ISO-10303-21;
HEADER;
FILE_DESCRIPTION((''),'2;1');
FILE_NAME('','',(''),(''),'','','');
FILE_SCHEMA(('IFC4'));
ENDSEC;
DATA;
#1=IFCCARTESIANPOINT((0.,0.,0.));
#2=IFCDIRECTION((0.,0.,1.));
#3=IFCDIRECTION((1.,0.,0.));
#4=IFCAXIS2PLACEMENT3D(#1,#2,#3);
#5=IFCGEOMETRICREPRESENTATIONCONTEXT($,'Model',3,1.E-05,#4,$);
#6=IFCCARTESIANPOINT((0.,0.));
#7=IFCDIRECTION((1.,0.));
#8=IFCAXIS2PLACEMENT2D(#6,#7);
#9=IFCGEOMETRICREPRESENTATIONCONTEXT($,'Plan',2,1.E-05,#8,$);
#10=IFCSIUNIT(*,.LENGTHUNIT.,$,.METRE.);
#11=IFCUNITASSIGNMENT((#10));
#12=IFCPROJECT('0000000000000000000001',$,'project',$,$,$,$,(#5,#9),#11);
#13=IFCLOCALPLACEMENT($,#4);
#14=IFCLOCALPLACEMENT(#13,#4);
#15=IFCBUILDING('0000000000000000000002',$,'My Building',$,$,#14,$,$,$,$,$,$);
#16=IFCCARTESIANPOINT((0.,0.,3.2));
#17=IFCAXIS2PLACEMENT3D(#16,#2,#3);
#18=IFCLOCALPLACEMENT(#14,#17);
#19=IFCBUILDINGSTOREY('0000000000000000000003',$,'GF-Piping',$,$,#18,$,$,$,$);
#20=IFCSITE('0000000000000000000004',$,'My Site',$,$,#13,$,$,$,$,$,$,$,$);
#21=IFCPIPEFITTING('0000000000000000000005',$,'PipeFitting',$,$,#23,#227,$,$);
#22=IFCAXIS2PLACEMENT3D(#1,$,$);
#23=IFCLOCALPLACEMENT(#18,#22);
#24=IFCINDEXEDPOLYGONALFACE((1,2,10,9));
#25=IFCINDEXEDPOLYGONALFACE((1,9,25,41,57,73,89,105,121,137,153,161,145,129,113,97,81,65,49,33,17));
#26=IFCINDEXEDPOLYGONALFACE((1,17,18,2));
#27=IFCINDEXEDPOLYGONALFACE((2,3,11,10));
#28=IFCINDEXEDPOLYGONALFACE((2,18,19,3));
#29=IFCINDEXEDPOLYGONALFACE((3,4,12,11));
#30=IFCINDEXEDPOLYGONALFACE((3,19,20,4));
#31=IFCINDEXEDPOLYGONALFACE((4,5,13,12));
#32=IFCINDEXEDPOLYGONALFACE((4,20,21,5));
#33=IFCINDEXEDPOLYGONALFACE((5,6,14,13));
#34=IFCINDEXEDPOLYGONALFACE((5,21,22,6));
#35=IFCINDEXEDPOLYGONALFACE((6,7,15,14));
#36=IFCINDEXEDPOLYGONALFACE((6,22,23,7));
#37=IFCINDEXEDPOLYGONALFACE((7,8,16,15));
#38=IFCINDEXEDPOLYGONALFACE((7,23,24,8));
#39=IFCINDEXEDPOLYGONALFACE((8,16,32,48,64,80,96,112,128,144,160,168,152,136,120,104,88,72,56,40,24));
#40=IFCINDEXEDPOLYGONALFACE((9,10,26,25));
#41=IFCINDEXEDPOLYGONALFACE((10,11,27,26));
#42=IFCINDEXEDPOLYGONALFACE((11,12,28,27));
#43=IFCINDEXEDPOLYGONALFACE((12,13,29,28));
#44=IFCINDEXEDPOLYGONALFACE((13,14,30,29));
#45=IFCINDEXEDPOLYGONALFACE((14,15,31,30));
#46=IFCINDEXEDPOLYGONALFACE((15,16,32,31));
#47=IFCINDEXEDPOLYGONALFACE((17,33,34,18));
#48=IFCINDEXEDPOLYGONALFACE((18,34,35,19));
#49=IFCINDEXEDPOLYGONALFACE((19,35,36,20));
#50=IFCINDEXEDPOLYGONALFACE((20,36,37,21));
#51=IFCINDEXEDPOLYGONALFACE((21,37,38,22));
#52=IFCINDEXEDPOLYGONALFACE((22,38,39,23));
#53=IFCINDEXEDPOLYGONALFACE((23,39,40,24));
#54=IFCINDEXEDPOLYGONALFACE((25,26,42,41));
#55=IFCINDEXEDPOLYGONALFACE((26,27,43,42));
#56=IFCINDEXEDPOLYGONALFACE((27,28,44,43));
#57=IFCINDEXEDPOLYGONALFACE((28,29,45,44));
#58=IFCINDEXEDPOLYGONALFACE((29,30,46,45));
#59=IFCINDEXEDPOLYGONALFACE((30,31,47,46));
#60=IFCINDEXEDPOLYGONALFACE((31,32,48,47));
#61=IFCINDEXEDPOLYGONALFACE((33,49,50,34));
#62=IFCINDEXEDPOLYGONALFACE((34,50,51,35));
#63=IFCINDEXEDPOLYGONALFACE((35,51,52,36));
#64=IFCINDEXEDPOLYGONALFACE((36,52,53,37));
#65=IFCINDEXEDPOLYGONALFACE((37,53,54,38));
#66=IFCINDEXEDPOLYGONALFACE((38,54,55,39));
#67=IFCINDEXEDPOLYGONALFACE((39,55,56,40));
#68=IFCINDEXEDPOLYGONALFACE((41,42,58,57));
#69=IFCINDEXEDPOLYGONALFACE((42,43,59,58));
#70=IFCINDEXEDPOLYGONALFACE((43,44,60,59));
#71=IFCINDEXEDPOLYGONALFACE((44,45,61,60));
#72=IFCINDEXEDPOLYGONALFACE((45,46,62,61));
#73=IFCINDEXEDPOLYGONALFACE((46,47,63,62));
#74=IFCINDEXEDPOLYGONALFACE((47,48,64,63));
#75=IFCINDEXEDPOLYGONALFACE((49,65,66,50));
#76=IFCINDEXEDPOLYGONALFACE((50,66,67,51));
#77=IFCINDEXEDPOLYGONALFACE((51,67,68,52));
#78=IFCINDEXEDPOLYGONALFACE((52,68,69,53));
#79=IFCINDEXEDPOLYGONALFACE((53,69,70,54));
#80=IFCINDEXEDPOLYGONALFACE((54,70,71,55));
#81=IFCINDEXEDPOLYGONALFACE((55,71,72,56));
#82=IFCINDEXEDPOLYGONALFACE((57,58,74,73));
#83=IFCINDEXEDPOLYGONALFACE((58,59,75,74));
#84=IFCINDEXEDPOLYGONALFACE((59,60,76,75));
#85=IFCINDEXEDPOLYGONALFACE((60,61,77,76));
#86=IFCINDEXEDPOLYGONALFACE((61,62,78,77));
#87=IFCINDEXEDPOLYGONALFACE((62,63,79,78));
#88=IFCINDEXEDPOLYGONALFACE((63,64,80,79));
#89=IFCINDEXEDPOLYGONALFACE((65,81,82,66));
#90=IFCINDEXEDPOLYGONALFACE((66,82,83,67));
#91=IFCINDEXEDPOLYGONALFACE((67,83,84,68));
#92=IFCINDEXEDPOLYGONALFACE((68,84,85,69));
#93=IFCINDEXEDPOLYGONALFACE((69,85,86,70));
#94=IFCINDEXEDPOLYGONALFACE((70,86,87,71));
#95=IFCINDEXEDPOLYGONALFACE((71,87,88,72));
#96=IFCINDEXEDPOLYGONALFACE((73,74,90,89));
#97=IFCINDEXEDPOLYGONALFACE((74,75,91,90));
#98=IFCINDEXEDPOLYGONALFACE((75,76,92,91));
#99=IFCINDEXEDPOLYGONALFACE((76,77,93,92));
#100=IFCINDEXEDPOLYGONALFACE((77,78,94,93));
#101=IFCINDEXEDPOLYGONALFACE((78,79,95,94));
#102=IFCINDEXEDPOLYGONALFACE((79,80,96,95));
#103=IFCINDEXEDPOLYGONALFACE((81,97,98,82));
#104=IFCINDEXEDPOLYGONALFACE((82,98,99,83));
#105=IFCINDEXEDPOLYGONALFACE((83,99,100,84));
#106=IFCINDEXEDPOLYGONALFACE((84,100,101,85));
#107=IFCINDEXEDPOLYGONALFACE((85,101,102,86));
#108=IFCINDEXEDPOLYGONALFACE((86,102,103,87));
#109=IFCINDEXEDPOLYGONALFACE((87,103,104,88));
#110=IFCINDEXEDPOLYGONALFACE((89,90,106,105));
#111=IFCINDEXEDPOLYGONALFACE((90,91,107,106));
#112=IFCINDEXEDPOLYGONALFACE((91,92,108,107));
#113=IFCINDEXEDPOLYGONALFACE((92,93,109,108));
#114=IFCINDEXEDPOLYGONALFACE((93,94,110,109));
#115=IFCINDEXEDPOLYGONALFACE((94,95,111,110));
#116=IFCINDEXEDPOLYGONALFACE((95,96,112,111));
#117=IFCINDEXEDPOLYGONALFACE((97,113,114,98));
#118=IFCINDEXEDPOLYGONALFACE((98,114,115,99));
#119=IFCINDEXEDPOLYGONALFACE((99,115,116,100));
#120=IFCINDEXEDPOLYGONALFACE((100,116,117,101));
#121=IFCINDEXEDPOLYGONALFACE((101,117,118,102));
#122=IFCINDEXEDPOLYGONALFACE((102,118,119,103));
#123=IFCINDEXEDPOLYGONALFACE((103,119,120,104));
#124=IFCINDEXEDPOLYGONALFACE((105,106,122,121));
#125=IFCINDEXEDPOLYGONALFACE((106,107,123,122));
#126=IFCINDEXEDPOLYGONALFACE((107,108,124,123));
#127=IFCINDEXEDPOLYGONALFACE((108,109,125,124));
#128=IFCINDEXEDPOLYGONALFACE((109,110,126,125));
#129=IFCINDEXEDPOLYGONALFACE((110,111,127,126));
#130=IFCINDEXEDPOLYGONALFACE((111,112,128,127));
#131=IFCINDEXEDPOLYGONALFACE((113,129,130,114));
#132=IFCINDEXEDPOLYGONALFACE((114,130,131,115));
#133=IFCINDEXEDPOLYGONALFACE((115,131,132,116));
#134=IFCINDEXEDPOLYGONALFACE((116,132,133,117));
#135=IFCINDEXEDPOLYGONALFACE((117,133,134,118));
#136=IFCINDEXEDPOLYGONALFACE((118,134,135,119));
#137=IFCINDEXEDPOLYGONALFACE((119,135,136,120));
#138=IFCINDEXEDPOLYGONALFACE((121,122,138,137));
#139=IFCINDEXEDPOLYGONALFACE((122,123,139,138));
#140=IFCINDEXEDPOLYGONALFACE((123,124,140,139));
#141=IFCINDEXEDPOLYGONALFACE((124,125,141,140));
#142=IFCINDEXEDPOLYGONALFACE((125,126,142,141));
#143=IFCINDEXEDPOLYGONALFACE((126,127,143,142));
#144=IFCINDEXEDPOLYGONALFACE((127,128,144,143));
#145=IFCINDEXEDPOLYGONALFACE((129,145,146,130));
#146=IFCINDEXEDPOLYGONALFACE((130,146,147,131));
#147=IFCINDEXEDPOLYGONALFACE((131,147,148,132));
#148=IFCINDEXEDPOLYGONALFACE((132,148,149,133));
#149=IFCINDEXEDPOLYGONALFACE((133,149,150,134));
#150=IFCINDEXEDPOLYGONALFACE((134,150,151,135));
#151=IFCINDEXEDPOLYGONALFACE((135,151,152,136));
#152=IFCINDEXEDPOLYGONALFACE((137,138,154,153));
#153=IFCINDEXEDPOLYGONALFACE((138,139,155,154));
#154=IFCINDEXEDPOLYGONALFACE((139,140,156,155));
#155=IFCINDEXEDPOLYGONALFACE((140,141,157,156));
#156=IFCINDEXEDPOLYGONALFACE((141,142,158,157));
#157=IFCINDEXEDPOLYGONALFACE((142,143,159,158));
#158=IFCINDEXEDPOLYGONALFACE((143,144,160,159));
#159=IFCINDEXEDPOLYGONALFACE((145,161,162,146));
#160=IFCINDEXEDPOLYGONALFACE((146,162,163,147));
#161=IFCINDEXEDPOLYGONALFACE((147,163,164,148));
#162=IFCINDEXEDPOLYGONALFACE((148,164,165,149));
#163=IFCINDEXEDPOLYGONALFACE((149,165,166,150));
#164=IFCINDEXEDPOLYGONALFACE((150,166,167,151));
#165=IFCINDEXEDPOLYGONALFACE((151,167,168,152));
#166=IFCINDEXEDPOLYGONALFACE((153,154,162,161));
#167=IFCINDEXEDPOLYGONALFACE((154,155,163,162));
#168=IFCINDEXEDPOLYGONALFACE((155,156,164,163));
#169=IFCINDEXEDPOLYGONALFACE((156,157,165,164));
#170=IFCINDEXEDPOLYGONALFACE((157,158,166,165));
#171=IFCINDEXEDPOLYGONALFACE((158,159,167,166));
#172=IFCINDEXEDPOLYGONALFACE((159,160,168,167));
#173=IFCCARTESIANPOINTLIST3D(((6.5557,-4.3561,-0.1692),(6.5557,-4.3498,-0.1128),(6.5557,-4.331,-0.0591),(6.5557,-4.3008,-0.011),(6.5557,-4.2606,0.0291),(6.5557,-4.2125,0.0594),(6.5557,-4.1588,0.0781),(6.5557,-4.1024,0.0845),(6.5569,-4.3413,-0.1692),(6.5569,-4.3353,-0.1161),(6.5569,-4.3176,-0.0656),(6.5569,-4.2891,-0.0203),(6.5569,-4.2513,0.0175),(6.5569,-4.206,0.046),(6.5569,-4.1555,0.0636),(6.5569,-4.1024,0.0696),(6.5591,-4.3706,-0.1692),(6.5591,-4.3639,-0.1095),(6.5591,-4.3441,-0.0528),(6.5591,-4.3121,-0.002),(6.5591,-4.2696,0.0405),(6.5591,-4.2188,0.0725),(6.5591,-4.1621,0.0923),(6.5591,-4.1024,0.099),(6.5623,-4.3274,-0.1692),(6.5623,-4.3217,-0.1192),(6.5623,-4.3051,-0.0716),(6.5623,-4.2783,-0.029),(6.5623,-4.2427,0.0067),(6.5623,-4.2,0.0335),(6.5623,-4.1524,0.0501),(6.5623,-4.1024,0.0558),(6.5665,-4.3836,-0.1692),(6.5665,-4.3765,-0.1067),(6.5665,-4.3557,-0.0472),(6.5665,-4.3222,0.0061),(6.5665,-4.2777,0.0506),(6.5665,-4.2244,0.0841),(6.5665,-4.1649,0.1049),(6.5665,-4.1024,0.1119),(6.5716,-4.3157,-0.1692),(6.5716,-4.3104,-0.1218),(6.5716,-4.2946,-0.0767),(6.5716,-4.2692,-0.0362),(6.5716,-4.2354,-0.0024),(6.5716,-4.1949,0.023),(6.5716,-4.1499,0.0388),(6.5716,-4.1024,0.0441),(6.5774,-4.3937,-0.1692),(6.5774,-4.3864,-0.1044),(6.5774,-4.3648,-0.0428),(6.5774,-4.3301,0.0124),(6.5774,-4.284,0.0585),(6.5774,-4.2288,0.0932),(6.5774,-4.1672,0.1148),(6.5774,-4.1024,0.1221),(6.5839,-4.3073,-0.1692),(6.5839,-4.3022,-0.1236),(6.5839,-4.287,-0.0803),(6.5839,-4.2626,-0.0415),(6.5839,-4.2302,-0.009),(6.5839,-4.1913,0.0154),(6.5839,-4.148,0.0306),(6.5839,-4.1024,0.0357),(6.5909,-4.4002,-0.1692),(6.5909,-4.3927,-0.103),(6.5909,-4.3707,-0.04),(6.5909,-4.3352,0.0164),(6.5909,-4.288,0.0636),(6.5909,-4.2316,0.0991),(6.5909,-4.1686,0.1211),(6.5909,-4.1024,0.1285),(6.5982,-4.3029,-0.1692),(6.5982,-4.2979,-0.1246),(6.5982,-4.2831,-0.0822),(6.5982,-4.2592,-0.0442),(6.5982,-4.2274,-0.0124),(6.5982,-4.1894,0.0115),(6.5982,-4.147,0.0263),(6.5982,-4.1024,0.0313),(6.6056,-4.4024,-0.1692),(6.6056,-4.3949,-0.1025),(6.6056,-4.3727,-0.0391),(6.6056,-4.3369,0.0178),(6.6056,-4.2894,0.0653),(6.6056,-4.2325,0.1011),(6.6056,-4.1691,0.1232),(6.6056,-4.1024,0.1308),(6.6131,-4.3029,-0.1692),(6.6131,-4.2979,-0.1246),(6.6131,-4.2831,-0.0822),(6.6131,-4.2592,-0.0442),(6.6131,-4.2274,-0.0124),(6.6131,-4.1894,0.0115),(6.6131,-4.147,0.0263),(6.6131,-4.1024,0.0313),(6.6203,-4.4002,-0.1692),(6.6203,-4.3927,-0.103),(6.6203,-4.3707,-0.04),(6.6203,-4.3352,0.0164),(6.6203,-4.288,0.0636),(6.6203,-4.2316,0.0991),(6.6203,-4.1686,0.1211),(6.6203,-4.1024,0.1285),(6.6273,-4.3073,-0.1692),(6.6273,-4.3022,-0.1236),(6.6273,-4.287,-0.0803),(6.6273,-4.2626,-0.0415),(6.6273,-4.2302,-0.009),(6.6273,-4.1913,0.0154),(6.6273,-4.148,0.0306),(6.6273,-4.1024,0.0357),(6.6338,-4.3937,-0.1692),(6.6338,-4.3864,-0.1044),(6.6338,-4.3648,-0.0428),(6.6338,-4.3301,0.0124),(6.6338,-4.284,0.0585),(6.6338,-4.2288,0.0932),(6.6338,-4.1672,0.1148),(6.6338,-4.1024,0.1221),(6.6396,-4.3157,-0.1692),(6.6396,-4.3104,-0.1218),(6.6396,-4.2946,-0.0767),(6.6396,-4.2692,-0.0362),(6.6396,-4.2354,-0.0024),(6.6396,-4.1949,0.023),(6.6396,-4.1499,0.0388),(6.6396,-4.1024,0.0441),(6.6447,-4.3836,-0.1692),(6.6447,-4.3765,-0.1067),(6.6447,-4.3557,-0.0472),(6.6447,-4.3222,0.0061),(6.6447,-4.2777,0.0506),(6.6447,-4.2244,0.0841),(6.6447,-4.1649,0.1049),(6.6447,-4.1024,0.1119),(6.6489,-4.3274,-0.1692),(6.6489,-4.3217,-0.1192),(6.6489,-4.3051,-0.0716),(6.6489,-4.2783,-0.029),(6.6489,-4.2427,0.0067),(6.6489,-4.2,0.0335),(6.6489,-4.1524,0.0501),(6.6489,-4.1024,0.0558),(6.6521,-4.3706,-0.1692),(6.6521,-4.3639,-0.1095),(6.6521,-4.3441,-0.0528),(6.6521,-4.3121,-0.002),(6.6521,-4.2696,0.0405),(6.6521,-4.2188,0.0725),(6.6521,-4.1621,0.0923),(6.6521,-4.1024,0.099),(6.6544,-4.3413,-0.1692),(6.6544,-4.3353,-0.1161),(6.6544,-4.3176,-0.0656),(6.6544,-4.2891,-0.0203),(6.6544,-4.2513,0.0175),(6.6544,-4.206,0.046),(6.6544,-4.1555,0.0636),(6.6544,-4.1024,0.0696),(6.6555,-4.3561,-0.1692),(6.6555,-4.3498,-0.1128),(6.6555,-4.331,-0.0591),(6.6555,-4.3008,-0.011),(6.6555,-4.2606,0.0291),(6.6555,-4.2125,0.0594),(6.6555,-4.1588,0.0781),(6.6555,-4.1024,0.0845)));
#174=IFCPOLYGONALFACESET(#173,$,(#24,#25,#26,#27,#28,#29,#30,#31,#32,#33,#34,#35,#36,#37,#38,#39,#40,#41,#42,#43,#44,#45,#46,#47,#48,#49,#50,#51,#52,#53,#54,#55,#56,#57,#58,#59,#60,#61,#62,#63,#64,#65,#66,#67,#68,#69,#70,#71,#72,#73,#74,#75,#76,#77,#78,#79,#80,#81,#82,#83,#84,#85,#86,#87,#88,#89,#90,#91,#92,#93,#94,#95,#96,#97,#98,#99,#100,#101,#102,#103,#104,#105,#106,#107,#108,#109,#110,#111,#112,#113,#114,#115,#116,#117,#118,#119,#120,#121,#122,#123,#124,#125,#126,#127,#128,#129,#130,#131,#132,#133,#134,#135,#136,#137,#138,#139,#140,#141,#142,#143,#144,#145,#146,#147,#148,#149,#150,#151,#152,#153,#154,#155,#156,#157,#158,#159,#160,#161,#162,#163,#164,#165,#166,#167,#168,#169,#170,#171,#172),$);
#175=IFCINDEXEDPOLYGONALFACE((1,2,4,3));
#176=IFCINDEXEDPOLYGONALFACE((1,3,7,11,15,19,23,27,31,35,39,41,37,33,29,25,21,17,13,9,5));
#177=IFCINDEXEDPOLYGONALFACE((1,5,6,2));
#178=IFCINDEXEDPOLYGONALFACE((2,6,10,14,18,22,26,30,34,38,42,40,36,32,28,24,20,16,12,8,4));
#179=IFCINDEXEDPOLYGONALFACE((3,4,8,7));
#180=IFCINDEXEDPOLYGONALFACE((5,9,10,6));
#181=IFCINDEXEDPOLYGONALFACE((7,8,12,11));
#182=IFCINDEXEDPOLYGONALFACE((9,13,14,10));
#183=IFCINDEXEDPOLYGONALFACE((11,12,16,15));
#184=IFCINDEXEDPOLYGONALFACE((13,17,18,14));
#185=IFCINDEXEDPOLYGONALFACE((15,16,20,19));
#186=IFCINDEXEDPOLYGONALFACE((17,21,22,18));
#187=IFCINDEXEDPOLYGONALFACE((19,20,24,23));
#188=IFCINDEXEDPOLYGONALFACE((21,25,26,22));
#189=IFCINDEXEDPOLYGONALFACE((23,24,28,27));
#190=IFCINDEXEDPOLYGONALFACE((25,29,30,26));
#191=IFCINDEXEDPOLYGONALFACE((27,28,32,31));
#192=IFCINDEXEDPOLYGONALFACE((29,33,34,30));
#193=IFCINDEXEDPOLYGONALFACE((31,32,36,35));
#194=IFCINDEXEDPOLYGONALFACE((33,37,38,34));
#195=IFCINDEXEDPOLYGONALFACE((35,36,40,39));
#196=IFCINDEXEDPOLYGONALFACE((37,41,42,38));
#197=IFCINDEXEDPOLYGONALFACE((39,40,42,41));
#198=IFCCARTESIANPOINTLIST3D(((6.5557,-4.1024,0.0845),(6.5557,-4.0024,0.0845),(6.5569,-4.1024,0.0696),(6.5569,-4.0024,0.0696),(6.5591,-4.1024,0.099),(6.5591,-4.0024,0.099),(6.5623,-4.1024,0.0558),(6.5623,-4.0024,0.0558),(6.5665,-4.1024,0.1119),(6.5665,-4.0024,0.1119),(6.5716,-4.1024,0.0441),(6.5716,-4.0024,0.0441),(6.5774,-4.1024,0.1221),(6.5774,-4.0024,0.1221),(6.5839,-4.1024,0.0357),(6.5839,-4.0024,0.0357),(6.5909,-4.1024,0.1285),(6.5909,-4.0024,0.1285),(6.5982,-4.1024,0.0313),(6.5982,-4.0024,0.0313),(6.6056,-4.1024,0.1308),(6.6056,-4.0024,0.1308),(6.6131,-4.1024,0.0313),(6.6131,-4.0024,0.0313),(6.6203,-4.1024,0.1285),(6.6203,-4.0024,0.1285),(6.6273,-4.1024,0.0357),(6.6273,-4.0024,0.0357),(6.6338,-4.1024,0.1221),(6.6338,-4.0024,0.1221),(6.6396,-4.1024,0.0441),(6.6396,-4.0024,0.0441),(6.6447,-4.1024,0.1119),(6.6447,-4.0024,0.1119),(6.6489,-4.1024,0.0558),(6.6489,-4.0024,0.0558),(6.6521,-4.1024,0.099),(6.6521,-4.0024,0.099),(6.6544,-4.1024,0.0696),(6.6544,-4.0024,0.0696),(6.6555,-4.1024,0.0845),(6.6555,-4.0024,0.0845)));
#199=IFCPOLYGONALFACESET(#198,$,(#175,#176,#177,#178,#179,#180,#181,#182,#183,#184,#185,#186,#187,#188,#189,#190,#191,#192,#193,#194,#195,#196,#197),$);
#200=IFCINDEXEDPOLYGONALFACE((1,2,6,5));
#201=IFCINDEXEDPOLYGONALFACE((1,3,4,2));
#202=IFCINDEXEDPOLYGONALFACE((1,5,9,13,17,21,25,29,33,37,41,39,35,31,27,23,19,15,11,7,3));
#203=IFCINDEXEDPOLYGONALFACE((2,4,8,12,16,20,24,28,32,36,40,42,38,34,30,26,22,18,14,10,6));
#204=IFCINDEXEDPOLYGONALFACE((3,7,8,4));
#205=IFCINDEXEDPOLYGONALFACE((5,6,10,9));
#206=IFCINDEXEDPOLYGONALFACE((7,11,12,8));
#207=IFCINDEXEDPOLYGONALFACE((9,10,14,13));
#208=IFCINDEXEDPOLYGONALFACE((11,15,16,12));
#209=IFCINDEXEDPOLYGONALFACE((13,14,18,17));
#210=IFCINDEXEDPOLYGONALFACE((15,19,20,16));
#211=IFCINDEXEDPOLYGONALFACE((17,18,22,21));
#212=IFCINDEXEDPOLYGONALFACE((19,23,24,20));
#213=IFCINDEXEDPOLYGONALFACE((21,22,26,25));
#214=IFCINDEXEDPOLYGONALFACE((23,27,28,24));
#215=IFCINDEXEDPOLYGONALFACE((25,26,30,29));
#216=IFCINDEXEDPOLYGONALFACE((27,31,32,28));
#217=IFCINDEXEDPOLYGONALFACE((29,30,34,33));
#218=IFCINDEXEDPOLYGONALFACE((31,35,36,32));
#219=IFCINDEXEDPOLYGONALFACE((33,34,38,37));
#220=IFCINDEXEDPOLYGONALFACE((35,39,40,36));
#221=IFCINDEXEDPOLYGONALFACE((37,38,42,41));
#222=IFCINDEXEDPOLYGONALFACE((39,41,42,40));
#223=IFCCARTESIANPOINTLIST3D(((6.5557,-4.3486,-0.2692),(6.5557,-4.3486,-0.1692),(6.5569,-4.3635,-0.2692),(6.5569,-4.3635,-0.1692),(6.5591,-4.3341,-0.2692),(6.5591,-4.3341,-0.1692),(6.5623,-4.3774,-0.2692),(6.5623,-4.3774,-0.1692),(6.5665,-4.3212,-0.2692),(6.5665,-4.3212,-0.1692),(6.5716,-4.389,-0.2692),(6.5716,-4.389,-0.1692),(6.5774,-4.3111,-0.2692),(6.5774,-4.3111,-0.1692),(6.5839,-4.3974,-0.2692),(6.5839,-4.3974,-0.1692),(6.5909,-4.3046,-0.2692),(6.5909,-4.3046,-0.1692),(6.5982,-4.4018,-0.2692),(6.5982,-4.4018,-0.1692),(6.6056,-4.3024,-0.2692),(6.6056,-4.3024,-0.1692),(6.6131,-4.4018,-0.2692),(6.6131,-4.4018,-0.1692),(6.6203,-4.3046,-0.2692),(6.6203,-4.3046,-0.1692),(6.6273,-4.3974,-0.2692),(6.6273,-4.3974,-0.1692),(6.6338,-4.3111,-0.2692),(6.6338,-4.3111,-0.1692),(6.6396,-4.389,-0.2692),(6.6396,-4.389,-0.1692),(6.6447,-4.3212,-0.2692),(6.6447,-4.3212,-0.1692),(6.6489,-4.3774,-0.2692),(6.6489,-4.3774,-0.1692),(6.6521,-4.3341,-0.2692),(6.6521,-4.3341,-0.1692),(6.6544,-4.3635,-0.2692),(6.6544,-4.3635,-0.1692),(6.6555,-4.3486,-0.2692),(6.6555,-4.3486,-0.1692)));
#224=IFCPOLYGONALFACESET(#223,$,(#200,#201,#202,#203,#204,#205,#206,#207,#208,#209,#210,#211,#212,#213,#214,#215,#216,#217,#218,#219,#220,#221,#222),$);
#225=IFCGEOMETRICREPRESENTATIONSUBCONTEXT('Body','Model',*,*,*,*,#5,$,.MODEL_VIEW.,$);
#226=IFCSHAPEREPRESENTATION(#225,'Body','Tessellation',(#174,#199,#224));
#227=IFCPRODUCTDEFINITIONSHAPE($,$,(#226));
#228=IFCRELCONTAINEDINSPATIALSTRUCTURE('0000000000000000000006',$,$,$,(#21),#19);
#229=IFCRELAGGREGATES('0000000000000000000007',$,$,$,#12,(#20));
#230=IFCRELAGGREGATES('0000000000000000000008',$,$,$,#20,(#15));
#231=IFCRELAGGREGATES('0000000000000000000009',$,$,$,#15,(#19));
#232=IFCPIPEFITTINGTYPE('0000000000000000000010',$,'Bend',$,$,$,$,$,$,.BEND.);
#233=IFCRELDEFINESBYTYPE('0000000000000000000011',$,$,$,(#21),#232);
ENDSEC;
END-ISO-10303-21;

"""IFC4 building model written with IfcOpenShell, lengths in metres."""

from ifc_helpers import new_model, entity, si_unit, frame, origin_with_axes, origin_2d_with_axis, place, context, subcontext, project, spatial, circle, extrude, source, transform, mapped, type_object, type_shapes, element, save


model = new_model("IFC4")

# Units and contexts
model_context = context("Model", 3, precision=1e-05, world=origin_with_axes())
plan_context = context("Plan", 2, precision=1e-05, world=origin_2d_with_axis())
body_context = subcontext(model_context, "Body", "Model", "MODEL_VIEW")
ifc_project = project(units=[si_unit("LENGTHUNIT", "METRE")], contexts=[model_context, plan_context])

# Site, building, storey
site_placement = place(None, origin_with_axes())
site = spatial("IfcSite", under=ifc_project, at=site_placement, Name="My Site")
building_placement = place(site_placement, origin_with_axes())
building = spatial("IfcBuilding", under=site, at=building_placement, Name="My Building")
storey_placement = place(building_placement, frame((0.0, 0.0, 3.2), z_axis=(0.0, 0.0, 1.0), x_axis=(1.0, 0.0, 0.0)))
storey = spatial("IfcBuildingStorey", under=building, at=storey_placement, Name="GF-Piping")

# Pipe fitting
pipe_fitting_type = type_object("IfcPipeFittingType", Name="Bend", PredefinedType="BEND")
shared_shape = source(origin_with_axes(), body_context, "Body", "SolidModel", [
    entity("IfcSweptDiskSolid", entity("IfcIndexedPolyCurve", entity("IfcCartesianPointList3D", [[0.0, 0.0, 0.1], [-0.0732, 0.0, 0.2768], [-0.25, 0.0, 0.35]]), [entity("IfcArcIndex", [1, 2, 3])]), 0.05),
    extrude(circle(Radius=0.05), origin_with_axes(), (0.0, 0.0, 1.0), 0.1),
    extrude(circle(Radius=0.05), frame((-0.25, 0.0, 0.35), z_axis=(-1.0, 0.0, 0.0), x_axis=(0.0, 0.0, -1.0)), (0.0, 0.0, 1.0), 0.1),
])
type_shapes(pipe_fitting_type, [shared_shape])
for number, where, z_axis, x_axis, name in (
    (1, (6.6056, -4.0024, 0.0808), (0.0, -1.0, 0.0), (0.0, 0.0, 1.0), "PipeFitting"),
):
    element("IfcPipeFitting", number, at=place(storey_placement, frame(where, z_axis=z_axis, x_axis=x_axis)), inside=storey, type_object=pipe_fitting_type, Name=name, context=body_context, shape_type="MappedRepresentation", body=[
        mapped(shared_shape, transform((0.0, 0.0, 0.0), x_axis=(1.0, 0.0, 0.0), y_axis=(0.0, 1.0, 0.0), z_axis=(0.0, 0.0, 1.0), scale=1.0)),
    ])

save(model, "model.ifc")
